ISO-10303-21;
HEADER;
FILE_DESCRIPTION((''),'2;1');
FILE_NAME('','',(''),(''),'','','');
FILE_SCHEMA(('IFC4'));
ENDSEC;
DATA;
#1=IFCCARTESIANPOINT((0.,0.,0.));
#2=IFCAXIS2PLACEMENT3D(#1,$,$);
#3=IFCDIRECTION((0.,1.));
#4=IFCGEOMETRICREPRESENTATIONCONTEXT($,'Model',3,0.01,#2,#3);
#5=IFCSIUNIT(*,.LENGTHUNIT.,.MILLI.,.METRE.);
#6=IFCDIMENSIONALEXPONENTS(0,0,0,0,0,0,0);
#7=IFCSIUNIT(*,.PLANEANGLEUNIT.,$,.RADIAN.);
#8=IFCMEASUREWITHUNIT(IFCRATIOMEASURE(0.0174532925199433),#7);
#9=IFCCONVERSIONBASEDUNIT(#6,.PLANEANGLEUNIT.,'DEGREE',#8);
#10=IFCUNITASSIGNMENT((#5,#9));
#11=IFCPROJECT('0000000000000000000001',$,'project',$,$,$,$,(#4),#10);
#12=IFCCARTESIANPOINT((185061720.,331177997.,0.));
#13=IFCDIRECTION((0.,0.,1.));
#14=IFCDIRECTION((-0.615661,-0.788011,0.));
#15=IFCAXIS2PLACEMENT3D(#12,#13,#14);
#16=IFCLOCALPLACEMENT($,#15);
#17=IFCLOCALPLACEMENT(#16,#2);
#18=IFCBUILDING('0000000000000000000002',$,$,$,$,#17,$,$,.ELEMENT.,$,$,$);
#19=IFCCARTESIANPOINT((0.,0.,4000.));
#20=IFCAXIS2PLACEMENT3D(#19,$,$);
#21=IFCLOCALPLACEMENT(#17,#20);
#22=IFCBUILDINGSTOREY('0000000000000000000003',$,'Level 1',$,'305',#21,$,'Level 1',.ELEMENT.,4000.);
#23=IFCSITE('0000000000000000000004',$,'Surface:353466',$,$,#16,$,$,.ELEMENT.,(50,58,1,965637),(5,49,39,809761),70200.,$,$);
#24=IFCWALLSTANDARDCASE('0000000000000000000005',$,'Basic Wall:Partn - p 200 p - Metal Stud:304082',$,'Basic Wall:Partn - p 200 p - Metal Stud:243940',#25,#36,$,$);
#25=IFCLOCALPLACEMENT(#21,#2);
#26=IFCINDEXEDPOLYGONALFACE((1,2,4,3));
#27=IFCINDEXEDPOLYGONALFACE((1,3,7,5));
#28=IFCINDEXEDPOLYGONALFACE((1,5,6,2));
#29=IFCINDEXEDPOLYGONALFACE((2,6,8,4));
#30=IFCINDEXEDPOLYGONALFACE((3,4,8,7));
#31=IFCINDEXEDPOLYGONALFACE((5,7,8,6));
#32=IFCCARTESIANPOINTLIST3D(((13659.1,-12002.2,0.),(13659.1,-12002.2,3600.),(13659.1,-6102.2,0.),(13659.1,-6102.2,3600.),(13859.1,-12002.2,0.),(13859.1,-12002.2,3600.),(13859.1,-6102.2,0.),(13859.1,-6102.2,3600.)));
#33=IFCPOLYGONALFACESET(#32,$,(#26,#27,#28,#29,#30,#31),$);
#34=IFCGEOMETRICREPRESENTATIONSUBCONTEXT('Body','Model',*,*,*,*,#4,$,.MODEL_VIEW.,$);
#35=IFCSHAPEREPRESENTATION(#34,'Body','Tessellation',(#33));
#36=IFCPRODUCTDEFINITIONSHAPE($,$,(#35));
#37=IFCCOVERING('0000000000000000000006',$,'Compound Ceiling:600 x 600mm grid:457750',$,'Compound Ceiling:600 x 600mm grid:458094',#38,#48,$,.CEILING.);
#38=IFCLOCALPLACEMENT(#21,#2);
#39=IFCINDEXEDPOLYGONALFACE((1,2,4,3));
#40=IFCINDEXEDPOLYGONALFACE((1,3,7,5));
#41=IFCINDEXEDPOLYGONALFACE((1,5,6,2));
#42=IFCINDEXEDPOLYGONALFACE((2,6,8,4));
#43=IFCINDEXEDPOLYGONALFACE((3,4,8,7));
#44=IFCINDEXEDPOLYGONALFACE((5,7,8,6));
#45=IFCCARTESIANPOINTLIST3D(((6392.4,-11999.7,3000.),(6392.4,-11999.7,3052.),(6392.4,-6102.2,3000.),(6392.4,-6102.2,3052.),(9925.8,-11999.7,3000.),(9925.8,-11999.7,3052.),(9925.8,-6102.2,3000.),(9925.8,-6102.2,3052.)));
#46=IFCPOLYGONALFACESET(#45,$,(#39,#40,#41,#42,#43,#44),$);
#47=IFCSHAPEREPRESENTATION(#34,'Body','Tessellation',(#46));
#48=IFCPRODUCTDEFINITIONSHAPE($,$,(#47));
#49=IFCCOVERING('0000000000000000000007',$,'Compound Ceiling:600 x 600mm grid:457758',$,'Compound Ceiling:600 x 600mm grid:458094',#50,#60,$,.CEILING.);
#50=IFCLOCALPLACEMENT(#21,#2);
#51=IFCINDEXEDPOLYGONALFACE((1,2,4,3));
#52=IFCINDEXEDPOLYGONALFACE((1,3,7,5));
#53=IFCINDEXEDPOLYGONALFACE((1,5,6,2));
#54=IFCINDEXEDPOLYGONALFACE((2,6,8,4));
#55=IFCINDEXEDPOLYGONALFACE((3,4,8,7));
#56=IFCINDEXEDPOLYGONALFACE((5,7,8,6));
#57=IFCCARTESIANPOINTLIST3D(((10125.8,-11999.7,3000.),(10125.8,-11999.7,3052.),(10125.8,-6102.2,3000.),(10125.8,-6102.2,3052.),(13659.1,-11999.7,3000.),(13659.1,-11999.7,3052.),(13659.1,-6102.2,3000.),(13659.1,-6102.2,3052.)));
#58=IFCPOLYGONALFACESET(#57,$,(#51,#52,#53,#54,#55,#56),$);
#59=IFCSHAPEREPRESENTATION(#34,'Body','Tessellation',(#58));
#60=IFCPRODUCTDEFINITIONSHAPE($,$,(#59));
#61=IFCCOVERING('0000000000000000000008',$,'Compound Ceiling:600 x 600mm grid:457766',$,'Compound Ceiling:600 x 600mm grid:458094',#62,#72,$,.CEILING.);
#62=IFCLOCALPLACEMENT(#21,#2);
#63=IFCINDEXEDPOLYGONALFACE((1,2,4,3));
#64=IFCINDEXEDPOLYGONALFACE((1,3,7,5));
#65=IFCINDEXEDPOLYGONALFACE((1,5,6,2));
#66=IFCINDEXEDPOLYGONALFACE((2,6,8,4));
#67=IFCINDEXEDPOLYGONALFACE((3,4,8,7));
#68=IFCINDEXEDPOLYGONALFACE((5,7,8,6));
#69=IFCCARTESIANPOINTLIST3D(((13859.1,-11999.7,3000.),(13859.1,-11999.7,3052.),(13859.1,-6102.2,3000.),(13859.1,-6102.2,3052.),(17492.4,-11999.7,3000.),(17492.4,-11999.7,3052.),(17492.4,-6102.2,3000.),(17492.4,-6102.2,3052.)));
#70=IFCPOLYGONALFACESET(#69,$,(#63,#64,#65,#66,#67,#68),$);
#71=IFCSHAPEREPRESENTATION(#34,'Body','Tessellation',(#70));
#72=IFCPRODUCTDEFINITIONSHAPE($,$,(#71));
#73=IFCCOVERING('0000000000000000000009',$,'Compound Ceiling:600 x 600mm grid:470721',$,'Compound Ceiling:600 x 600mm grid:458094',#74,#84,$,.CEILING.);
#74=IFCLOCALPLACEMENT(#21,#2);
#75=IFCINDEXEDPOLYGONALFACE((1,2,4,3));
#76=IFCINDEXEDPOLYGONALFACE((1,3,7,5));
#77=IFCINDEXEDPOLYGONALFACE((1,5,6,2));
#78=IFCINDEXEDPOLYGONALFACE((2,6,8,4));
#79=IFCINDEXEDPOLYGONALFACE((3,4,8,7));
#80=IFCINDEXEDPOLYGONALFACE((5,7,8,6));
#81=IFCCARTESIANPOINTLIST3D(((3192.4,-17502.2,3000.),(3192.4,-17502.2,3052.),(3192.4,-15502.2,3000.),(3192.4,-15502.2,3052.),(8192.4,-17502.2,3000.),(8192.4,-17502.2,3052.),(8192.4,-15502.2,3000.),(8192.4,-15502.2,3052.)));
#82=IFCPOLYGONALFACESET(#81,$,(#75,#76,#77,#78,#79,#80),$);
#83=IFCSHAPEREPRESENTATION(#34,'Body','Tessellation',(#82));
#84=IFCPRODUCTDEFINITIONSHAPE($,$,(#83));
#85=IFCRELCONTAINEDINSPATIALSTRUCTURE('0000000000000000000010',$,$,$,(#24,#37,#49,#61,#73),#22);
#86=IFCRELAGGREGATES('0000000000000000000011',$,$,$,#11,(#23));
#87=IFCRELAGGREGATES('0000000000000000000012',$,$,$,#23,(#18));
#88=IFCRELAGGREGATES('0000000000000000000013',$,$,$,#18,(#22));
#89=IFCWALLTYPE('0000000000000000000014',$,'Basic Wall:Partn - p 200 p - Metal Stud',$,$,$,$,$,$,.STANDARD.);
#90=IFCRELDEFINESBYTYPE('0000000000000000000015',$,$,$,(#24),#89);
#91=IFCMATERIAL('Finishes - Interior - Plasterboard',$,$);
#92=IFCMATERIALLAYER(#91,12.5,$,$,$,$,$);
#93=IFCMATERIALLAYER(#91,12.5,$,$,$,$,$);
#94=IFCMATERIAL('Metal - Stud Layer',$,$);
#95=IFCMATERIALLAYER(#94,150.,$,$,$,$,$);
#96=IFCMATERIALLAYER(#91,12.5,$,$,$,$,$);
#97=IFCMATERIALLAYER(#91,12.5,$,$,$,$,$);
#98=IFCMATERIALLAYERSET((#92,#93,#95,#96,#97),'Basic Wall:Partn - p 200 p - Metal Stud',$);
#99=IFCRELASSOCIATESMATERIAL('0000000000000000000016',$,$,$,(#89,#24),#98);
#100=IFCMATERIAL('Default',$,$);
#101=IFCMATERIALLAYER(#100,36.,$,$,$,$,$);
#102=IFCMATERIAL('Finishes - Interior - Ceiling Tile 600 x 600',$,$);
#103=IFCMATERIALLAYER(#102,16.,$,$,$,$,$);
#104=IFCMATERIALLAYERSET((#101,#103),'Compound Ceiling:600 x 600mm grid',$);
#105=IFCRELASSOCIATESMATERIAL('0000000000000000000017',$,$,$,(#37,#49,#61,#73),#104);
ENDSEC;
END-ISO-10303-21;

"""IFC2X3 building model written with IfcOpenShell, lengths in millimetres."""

from ifc_helpers import new_model, entity, si_unit, converted_unit, direction, frame, frame_2d, origin, place, context, subcontext, project, spatial, polyline, rectangle, extrude, clip, bounded_halfspace, material, layer, layer_set, layer_usage, type_object, element, save


model = new_model("IFC2X3")

# Units and contexts
model_context = context("Model", 3, precision=0.01, world=origin(), true_north=direction((0.0, 1.0)))
body_context = subcontext(model_context, "Body", "Model", "MODEL_VIEW")
ifc_project = project(units=[si_unit("LENGTHUNIT", "METRE", prefix="MILLI"), converted_unit("PLANEANGLEUNIT", "DEGREE", entity("IfcRatioMeasure", 0.0174532925199433), si_unit("PLANEANGLEUNIT", "RADIAN"), dimensions=[0, 0, 0, 0, 0, 0, 0])], contexts=[model_context])

# Site, building, storey
site_placement = place(None, frame((185061720.0, 331177997.0, 0.0), z_axis=(0.0, 0.0, 1.0), x_axis=(-0.615661, -0.788011, 0.0)))
site = spatial("IfcSite", under=ifc_project, at=site_placement, Name="Surface:353466", CompositionType="ELEMENT", RefLatitude=(50, 58, 1, 965637), RefLongitude=(5, 49, 39, 809761), RefElevation=70200.0)
building_placement = place(site_placement, origin())
building = spatial("IfcBuilding", under=site, at=building_placement, CompositionType="ELEMENT")
storey_placement = place(building_placement, frame((0.0, 0.0, 4000.0)))
storey = spatial("IfcBuildingStorey", under=building, at=storey_placement, Name="Level 1", ObjectType="305", LongName="Level 1", CompositionType="ELEMENT", Elevation=4000.0)

# Shared definitions
ifc_material_1 = material(Name="Finishes - Interior - Plasterboard")
ifc_material_2 = material(Name="Metal - Stud Layer")

# Wall
ifc_layer_1 = layer(ifc_material_1, 12.5)
ifc_layer_2 = layer(ifc_material_1, 12.5)
ifc_layer_3 = layer(ifc_material_2, 150.0)
ifc_layer_4 = layer(ifc_material_1, 12.5)
ifc_layer_5 = layer(ifc_material_1, 12.5)
ifc_layer_set_1 = layer_set([ifc_layer_1, ifc_layer_2, ifc_layer_3, ifc_layer_4, ifc_layer_5], Name="Basic Wall:Partn - p 200 p - Metal Stud")
ifc_layer_usage_1 = layer_usage(ifc_layer_set_1, "AXIS2", "NEGATIVE", 100.0)
wall_type_1 = type_object("IfcWallType", Name="Basic Wall:Partn - p 200 p - Metal Stud", PredefinedType="STANDARD", material=ifc_layer_set_1)
wall_1_placement = place(storey_placement, frame((13759.1, -6102.2, 0.0), z_axis=(0.0, 0.0, 1.0), x_axis=(0.0, -1.0, 0.0)))
element("IfcWallStandardCase", 1, at=wall_1_placement, inside=storey, type_object=wall_type_1, material=ifc_layer_usage_1, Name="Basic Wall:Partn - p 200 p - Metal Stud:304082", ObjectType="Basic Wall:Partn - p 200 p - Metal Stud:243940", context=body_context, shape_type="Clipping", body=[
    clip(extrude(rectangle(XDim=5900.0, YDim=200.0, at=frame_2d((2950.0, 0.0), x_axis=(-1.0, 0.0))), origin(), (0.0, 0.0, 1.0), 3600.0), bounded_halfspace(frame((0.0, -100.0, 3600.0), z_axis=(0.0, 0.0, -1.0), x_axis=(0.0, 1.0, 0.0)), True, frame((0.0, -100.0, 3600.0)), polyline([(0.0, 0.0), (5900.0, 0.0), (5900.0, 200.0), (0.0, 200.0), (0.0, 0.0)]))),
])

# Coverings
ifc_material_3 = material(Name="Default")
ifc_layer_6 = layer(ifc_material_3, 36.0)
ifc_material_4 = material(Name="Finishes - Interior - Ceiling Tile 600 x 600")
ifc_layer_7 = layer(ifc_material_4, 16.0)
ifc_layer_set_2 = layer_set([ifc_layer_6, ifc_layer_7], Name="Compound Ceiling:600 x 600mm grid")
ifc_layer_usage_2 = layer_usage(ifc_layer_set_2, "AXIS3", "POSITIVE", 0.0)
covering_1_placement = place(storey_placement, frame((6392.4, -11999.7, 3000.0)))
element("IfcCovering", 2, at=covering_1_placement, inside=storey, material=ifc_layer_usage_2, Name="Compound Ceiling:600 x 600mm grid:457750", ObjectType="Compound Ceiling:600 x 600mm grid:458094", PredefinedType="CEILING", context=body_context, shape_type="SweptSolid", body=[
    extrude(rectangle(XDim=3533.3, YDim=5897.5, at=frame_2d((0.0, 0.0), x_axis=(1.0, 0.0))), frame((1766.7, 2948.8, 0.0)), (0.0, 0.0, 1.0), 52.0),
])
ifc_layer_usage_3 = layer_usage(ifc_layer_set_2, "AXIS3", "POSITIVE", 0.0)
covering_2_placement = place(storey_placement, frame((10125.8, -11999.7, 3000.0)))
element("IfcCovering", 3, at=covering_2_placement, inside=storey, material=ifc_layer_usage_3, Name="Compound Ceiling:600 x 600mm grid:457758", ObjectType="Compound Ceiling:600 x 600mm grid:458094", PredefinedType="CEILING", context=body_context, shape_type="SweptSolid", body=[
    extrude(rectangle(XDim=3533.3, YDim=5897.5, at=frame_2d((0.0, 0.0), x_axis=(1.0, 0.0))), frame((1766.7, 2948.8, 0.0)), (0.0, 0.0, 1.0), 52.0),
])
ifc_layer_usage_4 = layer_usage(ifc_layer_set_2, "AXIS3", "POSITIVE", 0.0)
covering_3_placement = place(storey_placement, frame((13859.1, -11999.7, 3000.0)))
element("IfcCovering", 4, at=covering_3_placement, inside=storey, material=ifc_layer_usage_4, Name="Compound Ceiling:600 x 600mm grid:457766", ObjectType="Compound Ceiling:600 x 600mm grid:458094", PredefinedType="CEILING", context=body_context, shape_type="SweptSolid", body=[
    extrude(rectangle(XDim=3633.3, YDim=5897.5, at=frame_2d((0.0, 0.0), x_axis=(1.0, 0.0))), frame((1816.7, 2948.8, 0.0)), (0.0, 0.0, 1.0), 52.0),
])
ifc_layer_usage_5 = layer_usage(ifc_layer_set_2, "AXIS3", "POSITIVE", 0.0)
covering_4_placement = place(storey_placement, frame((3192.4, -17502.2, 3000.0)))
element("IfcCovering", 5, at=covering_4_placement, inside=storey, material=ifc_layer_usage_5, Name="Compound Ceiling:600 x 600mm grid:470721", ObjectType="Compound Ceiling:600 x 600mm grid:458094", PredefinedType="CEILING", context=body_context, shape_type="SweptSolid", body=[
    extrude(rectangle(XDim=2000.0, YDim=5000.0, at=frame_2d((0.0, 0.0), x_axis=(1.0, 0.0))), frame((2500.0, 1000.0, 0.0), z_axis=(0.0, 0.0, 1.0), x_axis=(0.0, -1.0, 0.0)), (0.0, 0.0, 1.0), 52.0),
])

save(model, "model.ifc")
